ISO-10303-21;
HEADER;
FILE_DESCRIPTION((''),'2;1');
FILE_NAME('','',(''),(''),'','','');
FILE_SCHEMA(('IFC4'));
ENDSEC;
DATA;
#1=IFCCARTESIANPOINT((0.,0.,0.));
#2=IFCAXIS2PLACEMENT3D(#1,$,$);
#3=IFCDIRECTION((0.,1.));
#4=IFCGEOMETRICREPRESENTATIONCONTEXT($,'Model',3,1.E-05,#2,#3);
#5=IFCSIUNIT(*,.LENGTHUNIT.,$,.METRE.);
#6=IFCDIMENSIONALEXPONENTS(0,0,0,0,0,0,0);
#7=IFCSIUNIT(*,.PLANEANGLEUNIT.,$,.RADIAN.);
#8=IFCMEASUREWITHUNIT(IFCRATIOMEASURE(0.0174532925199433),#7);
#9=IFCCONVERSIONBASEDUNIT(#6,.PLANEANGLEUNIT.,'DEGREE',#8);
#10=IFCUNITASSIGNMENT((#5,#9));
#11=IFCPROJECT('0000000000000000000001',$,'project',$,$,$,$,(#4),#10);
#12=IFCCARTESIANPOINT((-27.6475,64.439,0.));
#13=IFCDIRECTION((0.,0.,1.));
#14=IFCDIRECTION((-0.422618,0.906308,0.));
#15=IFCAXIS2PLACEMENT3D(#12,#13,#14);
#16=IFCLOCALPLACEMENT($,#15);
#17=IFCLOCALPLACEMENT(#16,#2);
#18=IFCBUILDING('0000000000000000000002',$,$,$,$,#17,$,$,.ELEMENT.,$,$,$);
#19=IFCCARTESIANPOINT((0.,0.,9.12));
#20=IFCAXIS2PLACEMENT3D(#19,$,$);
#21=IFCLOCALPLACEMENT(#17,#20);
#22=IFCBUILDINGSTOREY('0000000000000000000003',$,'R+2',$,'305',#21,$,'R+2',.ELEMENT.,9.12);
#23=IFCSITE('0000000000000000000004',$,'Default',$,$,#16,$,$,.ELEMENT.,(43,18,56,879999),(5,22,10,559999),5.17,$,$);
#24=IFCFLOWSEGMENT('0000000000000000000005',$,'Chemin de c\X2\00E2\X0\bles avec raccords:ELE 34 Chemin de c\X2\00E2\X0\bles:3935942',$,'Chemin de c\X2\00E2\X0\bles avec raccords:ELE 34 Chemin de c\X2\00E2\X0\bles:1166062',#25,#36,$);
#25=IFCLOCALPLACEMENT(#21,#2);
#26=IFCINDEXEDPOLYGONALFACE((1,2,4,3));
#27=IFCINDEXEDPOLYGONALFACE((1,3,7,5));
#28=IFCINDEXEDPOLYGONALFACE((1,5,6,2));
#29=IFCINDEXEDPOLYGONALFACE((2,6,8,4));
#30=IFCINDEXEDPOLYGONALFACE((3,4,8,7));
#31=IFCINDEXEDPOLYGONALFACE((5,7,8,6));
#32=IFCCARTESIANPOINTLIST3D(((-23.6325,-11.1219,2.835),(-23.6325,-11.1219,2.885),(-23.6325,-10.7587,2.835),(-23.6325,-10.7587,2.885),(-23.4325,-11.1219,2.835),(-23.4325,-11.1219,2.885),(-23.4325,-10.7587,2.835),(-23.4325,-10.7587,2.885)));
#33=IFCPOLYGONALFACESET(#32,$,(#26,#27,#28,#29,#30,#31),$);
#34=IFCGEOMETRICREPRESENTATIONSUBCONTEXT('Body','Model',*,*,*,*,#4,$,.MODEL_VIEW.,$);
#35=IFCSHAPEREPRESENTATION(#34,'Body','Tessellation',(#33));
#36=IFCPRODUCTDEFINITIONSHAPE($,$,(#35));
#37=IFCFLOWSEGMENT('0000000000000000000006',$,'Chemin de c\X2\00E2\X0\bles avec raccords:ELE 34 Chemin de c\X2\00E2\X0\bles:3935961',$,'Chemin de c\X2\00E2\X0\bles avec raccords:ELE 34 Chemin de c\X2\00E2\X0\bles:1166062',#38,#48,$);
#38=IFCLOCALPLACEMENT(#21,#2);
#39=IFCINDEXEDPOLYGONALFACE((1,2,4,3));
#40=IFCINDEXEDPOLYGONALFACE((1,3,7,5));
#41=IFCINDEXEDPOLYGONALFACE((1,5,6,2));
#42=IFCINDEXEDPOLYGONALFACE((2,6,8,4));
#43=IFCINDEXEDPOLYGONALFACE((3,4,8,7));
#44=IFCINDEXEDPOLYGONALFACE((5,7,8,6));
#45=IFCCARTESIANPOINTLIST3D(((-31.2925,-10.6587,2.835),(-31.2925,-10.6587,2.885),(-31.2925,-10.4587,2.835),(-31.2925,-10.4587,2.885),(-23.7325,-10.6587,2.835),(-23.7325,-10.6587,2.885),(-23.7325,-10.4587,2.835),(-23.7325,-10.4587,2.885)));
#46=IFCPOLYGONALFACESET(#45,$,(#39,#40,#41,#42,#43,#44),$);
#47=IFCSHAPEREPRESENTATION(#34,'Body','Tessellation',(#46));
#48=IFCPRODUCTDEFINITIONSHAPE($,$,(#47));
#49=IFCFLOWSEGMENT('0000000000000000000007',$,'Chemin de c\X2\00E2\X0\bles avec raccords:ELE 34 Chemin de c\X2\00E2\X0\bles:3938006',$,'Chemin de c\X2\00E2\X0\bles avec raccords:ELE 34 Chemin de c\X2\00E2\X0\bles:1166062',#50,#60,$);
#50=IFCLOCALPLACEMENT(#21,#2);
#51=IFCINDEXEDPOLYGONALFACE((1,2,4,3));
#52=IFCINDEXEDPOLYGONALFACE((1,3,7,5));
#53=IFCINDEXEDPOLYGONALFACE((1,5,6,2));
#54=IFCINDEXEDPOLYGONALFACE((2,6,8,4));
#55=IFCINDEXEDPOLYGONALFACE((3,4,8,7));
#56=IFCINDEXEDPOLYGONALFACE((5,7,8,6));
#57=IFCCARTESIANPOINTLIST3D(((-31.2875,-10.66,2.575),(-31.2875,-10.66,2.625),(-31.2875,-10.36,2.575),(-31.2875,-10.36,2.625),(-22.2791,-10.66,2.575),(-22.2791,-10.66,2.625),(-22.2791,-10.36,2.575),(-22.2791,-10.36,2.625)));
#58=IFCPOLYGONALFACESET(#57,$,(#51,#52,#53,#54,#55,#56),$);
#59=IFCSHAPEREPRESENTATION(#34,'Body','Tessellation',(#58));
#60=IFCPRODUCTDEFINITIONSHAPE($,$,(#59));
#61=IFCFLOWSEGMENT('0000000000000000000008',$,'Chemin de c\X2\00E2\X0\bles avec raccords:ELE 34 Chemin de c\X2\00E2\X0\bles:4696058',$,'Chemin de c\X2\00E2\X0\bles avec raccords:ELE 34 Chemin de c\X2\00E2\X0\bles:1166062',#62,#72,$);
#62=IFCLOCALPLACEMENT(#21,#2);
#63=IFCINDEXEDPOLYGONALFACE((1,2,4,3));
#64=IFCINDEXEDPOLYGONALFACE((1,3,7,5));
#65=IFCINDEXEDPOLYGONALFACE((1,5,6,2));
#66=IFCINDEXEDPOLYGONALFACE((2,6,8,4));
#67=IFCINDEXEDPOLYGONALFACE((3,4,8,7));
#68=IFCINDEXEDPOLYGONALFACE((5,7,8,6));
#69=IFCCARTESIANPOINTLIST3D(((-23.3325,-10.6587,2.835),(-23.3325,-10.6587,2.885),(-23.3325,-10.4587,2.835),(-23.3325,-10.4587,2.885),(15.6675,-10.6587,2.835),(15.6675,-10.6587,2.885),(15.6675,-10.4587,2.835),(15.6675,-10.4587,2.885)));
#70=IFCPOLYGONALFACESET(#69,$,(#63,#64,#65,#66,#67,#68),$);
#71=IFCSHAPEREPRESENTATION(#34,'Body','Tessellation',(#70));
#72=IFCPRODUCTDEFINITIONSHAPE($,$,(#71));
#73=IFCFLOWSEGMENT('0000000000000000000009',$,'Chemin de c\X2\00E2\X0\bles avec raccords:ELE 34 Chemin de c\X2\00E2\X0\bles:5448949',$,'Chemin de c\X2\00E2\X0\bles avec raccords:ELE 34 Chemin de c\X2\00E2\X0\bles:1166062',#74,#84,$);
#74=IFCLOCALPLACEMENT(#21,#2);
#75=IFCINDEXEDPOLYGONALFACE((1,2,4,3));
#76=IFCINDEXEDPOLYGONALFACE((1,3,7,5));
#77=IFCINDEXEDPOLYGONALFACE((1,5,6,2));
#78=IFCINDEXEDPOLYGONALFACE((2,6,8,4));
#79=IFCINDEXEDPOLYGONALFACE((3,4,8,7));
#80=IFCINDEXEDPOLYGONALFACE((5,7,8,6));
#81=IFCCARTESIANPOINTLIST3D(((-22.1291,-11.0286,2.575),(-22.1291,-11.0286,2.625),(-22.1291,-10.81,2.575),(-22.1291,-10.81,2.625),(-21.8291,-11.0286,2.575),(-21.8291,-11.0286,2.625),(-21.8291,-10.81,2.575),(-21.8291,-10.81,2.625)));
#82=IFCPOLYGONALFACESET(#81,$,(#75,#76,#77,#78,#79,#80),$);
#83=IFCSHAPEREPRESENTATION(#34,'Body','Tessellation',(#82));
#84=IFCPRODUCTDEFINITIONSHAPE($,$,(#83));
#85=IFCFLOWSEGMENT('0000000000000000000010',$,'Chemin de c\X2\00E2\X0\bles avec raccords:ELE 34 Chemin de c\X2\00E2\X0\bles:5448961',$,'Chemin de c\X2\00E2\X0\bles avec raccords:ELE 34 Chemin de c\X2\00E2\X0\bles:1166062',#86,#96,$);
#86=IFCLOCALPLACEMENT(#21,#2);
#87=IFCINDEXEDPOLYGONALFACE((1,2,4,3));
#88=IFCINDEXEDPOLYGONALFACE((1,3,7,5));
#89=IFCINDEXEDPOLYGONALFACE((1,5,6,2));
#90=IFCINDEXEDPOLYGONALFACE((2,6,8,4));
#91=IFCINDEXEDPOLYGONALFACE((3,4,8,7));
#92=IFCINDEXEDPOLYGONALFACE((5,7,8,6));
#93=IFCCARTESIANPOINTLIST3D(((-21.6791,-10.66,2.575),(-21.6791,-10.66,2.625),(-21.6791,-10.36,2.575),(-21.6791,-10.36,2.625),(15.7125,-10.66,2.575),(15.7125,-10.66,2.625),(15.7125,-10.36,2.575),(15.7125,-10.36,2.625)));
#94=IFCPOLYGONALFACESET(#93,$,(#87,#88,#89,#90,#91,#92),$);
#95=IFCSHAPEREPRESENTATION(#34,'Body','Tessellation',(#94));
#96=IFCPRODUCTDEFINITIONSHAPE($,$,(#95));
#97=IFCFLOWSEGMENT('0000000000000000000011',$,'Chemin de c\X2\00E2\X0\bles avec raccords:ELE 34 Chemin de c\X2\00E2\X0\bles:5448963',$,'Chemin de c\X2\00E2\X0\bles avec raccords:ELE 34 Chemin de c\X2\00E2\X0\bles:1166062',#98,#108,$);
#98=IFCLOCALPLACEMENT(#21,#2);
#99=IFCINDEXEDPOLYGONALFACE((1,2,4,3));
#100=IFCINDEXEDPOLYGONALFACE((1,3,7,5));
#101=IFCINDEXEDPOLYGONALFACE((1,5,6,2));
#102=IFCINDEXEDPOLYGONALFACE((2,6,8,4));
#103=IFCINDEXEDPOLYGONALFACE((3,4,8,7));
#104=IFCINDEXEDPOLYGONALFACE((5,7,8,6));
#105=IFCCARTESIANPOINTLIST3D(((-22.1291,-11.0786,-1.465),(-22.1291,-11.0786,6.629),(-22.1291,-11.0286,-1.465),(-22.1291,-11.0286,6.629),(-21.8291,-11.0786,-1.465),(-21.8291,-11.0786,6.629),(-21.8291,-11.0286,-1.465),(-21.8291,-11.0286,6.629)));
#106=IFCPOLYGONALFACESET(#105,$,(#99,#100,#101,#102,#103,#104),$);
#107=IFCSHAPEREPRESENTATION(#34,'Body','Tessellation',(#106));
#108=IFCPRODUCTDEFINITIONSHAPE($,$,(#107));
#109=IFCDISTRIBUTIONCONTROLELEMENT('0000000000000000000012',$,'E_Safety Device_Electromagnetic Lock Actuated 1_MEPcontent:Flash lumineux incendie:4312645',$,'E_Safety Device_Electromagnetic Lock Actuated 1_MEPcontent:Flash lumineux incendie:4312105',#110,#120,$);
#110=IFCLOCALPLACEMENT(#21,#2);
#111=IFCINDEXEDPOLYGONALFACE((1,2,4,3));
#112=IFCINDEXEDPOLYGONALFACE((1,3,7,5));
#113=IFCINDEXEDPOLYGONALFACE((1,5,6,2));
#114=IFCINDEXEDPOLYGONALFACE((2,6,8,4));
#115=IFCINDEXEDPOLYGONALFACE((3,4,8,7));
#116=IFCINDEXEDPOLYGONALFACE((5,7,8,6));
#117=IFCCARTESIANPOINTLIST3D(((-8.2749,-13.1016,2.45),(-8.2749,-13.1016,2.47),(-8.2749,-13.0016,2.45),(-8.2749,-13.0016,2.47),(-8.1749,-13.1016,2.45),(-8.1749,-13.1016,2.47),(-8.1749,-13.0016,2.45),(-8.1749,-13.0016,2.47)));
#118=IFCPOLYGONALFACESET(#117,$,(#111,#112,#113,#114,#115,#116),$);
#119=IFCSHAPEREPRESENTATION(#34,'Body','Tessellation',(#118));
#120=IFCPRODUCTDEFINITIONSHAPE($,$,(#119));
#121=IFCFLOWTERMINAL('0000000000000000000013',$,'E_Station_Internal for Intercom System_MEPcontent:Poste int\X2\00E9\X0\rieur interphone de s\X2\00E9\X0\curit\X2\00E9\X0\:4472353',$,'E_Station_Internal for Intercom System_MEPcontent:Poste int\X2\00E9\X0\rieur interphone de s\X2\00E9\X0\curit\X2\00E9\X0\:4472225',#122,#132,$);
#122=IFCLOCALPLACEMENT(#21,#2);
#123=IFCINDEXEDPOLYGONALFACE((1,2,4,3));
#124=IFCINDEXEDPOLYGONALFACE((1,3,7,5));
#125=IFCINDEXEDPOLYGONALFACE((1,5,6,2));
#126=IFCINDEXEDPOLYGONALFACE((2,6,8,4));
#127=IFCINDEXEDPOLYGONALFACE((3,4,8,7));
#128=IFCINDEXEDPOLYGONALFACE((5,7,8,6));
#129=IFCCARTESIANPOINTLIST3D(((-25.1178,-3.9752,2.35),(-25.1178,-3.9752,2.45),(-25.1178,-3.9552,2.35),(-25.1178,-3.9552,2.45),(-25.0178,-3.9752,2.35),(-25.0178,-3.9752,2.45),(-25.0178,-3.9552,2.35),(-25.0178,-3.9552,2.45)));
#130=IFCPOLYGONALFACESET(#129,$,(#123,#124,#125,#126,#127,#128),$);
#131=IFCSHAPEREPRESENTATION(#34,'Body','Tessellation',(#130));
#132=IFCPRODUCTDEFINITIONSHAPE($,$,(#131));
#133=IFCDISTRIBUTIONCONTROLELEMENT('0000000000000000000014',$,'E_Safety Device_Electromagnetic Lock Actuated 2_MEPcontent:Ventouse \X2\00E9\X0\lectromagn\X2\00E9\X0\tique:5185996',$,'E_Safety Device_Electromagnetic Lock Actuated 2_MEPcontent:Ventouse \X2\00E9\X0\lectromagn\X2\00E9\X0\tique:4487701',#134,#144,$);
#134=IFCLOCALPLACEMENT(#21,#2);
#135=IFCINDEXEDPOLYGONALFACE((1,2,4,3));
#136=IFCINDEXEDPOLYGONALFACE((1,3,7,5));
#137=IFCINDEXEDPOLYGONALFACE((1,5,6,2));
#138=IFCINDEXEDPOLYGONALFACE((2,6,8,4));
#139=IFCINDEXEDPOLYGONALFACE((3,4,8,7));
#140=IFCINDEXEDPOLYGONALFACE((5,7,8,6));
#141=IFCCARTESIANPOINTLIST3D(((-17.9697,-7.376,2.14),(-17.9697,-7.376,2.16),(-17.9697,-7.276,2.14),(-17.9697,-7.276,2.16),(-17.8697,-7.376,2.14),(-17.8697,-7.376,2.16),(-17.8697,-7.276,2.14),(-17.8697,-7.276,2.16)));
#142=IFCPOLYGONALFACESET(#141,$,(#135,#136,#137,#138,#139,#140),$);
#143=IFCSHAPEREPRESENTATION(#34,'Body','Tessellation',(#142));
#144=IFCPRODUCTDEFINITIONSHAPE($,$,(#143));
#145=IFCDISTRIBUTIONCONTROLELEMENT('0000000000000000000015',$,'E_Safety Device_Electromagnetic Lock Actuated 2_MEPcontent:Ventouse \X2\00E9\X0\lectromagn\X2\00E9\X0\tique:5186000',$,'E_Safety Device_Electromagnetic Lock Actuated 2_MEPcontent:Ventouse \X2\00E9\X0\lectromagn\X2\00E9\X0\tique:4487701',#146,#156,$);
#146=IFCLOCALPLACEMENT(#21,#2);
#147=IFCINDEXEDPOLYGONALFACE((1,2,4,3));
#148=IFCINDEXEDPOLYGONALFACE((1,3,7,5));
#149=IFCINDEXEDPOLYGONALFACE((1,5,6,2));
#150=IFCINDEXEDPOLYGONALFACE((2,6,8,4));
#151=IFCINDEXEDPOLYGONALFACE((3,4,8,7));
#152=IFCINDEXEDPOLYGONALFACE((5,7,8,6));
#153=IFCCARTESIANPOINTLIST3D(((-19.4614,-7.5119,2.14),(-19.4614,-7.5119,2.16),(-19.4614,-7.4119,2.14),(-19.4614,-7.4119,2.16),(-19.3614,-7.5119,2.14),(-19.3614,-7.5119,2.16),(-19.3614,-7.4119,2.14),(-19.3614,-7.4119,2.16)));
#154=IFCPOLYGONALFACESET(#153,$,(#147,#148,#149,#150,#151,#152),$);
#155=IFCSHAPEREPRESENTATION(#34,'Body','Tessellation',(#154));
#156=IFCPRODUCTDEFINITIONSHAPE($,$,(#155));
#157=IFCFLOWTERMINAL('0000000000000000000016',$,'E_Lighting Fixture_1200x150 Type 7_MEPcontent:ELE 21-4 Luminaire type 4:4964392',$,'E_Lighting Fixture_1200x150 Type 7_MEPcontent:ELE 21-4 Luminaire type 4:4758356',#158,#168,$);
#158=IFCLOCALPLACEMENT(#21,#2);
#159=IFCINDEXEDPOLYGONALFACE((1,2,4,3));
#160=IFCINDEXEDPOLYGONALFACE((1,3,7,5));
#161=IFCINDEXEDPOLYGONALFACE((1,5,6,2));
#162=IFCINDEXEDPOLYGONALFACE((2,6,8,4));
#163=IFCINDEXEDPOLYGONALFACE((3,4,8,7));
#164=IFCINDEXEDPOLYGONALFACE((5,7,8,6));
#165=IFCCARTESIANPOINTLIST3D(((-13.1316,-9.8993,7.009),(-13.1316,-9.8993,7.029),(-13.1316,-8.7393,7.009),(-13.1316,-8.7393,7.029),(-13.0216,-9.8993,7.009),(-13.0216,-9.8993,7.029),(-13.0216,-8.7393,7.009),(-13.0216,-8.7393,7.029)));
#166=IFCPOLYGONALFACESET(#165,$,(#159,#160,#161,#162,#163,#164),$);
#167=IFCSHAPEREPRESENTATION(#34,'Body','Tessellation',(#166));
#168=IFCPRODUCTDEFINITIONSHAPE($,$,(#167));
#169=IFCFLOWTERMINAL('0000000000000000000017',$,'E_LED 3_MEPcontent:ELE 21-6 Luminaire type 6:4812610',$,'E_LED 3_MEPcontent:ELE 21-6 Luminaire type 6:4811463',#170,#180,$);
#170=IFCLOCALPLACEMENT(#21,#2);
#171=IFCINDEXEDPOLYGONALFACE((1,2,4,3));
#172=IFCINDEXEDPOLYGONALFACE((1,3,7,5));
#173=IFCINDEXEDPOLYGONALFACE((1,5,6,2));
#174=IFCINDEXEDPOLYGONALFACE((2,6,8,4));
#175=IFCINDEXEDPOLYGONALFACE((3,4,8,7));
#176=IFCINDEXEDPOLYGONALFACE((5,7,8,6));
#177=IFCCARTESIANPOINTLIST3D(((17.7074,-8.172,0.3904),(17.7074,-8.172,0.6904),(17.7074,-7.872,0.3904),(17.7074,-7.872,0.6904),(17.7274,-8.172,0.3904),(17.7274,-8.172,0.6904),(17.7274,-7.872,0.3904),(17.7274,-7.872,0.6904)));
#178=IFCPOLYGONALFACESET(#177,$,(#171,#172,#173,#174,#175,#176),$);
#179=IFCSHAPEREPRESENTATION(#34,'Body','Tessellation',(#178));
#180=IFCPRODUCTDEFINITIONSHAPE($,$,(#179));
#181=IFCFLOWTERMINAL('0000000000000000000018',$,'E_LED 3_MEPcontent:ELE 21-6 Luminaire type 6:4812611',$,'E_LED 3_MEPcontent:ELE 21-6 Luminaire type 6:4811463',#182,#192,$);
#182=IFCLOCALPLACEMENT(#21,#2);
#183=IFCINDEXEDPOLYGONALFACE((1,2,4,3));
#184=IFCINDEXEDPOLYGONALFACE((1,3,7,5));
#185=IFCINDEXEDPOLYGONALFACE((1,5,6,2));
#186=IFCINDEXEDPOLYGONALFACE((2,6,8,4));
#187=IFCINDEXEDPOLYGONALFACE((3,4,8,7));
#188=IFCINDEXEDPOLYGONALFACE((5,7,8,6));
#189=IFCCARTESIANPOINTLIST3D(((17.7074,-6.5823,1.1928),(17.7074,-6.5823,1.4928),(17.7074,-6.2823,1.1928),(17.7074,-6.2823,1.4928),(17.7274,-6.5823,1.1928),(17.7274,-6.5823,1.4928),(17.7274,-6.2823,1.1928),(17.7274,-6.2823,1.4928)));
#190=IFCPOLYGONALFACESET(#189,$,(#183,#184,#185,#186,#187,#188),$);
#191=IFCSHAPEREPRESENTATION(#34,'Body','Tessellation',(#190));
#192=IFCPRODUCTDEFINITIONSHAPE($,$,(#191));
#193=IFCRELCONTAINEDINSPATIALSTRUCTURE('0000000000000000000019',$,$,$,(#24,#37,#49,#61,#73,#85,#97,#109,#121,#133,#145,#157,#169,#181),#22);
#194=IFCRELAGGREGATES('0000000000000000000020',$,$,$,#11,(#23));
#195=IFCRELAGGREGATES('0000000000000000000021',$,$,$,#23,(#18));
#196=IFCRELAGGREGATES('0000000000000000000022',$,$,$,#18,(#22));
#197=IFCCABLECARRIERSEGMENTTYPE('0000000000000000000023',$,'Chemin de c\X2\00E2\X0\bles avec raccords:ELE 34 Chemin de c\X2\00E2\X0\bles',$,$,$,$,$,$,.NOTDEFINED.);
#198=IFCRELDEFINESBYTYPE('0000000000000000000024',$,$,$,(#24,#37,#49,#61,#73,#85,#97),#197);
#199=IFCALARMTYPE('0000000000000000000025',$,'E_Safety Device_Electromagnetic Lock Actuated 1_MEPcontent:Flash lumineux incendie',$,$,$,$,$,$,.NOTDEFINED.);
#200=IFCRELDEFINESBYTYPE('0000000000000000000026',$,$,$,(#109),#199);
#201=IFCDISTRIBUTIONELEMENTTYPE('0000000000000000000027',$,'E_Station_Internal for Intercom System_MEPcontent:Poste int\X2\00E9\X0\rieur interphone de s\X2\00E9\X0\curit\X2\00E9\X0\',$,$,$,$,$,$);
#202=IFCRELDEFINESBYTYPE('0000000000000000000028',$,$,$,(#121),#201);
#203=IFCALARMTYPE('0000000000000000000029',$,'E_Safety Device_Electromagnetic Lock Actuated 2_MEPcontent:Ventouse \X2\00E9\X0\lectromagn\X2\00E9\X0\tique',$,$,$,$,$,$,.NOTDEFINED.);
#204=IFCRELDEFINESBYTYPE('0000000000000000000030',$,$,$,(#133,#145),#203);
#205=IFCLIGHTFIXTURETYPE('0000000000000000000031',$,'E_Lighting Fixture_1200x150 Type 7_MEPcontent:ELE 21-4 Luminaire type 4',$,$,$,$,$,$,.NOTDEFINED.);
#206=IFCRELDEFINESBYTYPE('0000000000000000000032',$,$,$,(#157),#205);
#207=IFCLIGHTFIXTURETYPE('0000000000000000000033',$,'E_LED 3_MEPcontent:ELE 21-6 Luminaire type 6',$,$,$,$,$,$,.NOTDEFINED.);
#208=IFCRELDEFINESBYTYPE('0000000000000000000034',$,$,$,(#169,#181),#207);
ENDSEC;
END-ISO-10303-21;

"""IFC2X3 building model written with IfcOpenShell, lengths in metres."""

from ifc_helpers import new_model, entity, si_unit, converted_unit, direction, frame, frame_2d, origin, origin_2d_with_axis, place, context, subcontext, project, spatial, polyline, rectangle, outline, extrude, source, transform, mapped, type_object, type_shapes, element, save


model = new_model("IFC2X3")

# Units and contexts
model_context = context("Model", 3, precision=1e-05, world=origin(), true_north=direction((0.0, 1.0)))
body_context = subcontext(model_context, "Body", "Model", "MODEL_VIEW")
ifc_project = project(units=[si_unit("LENGTHUNIT", "METRE"), converted_unit("PLANEANGLEUNIT", "DEGREE", entity("IfcRatioMeasure", 0.0174532925199433), si_unit("PLANEANGLEUNIT", "RADIAN"), dimensions=[0, 0, 0, 0, 0, 0, 0])], contexts=[model_context])

# Site, building, storey
site_placement = place(None, frame((-27.6475, 64.439, 0.0), z_axis=(0.0, 0.0, 1.0), x_axis=(-0.422618, 0.906308, 0.0)))
site = spatial("IfcSite", under=ifc_project, at=site_placement, Name="Default", CompositionType="ELEMENT", RefLatitude=(43, 18, 56, 879999), RefLongitude=(5, 22, 10, 559999), RefElevation=5.17)
building_placement = place(site_placement, origin())
building = spatial("IfcBuilding", under=site, at=building_placement, CompositionType="ELEMENT")
storey_placement = place(building_placement, frame((0.0, 0.0, 9.12)))
storey = spatial("IfcBuildingStorey", under=building, at=storey_placement, Name="R+2", ObjectType="305", LongName="R+2", CompositionType="ELEMENT", Elevation=9.12)

# Flow segments
cable_carrier_segment_type = type_object("IfcCableCarrierSegmentType", Name="Chemin de câbles avec raccords:ELE 34 Chemin de câbles", PredefinedType="NOTDEFINED")
flow_segment_1_placement = place(storey_placement, origin())
element("IfcFlowSegment", 1, at=flow_segment_1_placement, inside=storey, type_object=cable_carrier_segment_type, Name="Chemin de câbles avec raccords:ELE 34 Chemin de câbles:3935942", ObjectType="Chemin de câbles avec raccords:ELE 34 Chemin de câbles:1166062", context=body_context, shape_type="SweptSolid", body=[
    extrude(outline(polyline([(-0.1, -0.1816), (0.1, -0.1816), (0.1, 0.1816), (-0.1, 0.1816), (-0.1, -0.1816)])), frame((-23.5325, -10.9403, 2.835)), (0.0, 0.0, 1.0), 0.05),
])
flow_segment_2_placement = place(storey_placement, origin())
element("IfcFlowSegment", 2, at=flow_segment_2_placement, inside=storey, type_object=cable_carrier_segment_type, Name="Chemin de câbles avec raccords:ELE 34 Chemin de câbles:3935961", ObjectType="Chemin de câbles avec raccords:ELE 34 Chemin de câbles:1166062", context=body_context, shape_type="SweptSolid", body=[
    extrude(rectangle(XDim=7.56, YDim=0.2, at=frame_2d((0.0, 0.0), x_axis=(1.0, 0.0))), frame((-27.5125, -10.5587, 2.835), z_axis=(0.0, 0.0, 1.0), x_axis=(-1.0, 0.0, 0.0)), (0.0, 0.0, 1.0), 0.05),
])
flow_segment_3_placement = place(storey_placement, origin())
element("IfcFlowSegment", 3, at=flow_segment_3_placement, inside=storey, type_object=cable_carrier_segment_type, Name="Chemin de câbles avec raccords:ELE 34 Chemin de câbles:3938006", ObjectType="Chemin de câbles avec raccords:ELE 34 Chemin de câbles:1166062", context=body_context, shape_type="SweptSolid", body=[
    extrude(rectangle(XDim=9.0084, YDim=0.3, at=frame_2d((0.0, 0.0), x_axis=(1.0, 0.0))), frame((-26.7833, -10.51, 2.575), z_axis=(0.0, 0.0, 1.0), x_axis=(-1.0, 0.0, 0.0)), (0.0, 0.0, 1.0), 0.05),
])
flow_segment_4_placement = place(storey_placement, origin())
element("IfcFlowSegment", 4, at=flow_segment_4_placement, inside=storey, type_object=cable_carrier_segment_type, Name="Chemin de câbles avec raccords:ELE 34 Chemin de câbles:4696058", ObjectType="Chemin de câbles avec raccords:ELE 34 Chemin de câbles:1166062", context=body_context, shape_type="SweptSolid", body=[
    extrude(rectangle(XDim=39.0, YDim=0.2, at=frame_2d((0.0, 0.0), x_axis=(1.0, 0.0))), frame((-3.8325, -10.5587, 2.835)), (0.0, 0.0, 1.0), 0.05),
])
flow_segment_5_placement = place(storey_placement, origin())
element("IfcFlowSegment", 5, at=flow_segment_5_placement, inside=storey, type_object=cable_carrier_segment_type, Name="Chemin de câbles avec raccords:ELE 34 Chemin de câbles:5448949", ObjectType="Chemin de câbles avec raccords:ELE 34 Chemin de câbles:1166062", context=body_context, shape_type="SweptSolid", body=[
    extrude(rectangle(XDim=0.2186, YDim=0.3, at=frame_2d((0.0, 0.0), x_axis=(1.0, 0.0))), frame((-21.9791, -10.9193, 2.575), z_axis=(0.0, 0.0, 1.0), x_axis=(0.0, -1.0, 0.0)), (0.0, 0.0, 1.0), 0.05),
])
flow_segment_6_placement = place(storey_placement, origin())
element("IfcFlowSegment", 6, at=flow_segment_6_placement, inside=storey, type_object=cable_carrier_segment_type, Name="Chemin de câbles avec raccords:ELE 34 Chemin de câbles:5448961", ObjectType="Chemin de câbles avec raccords:ELE 34 Chemin de câbles:1166062", context=body_context, shape_type="SweptSolid", body=[
    extrude(rectangle(XDim=37.3916, YDim=0.3, at=frame_2d((0.0, 0.0), x_axis=(1.0, 0.0))), frame((-2.9833, -10.51, 2.575), z_axis=(0.0, 0.0, 1.0), x_axis=(-1.0, 0.0, 0.0)), (0.0, 0.0, 1.0), 0.05),
])
flow_segment_7_placement = place(storey_placement, origin())
element("IfcFlowSegment", 7, at=flow_segment_7_placement, inside=storey, type_object=cable_carrier_segment_type, Name="Chemin de câbles avec raccords:ELE 34 Chemin de câbles:5448963", ObjectType="Chemin de câbles avec raccords:ELE 34 Chemin de câbles:1166062", context=body_context, shape_type="SweptSolid", body=[
    extrude(rectangle(XDim=0.3, YDim=0.05, at=origin_2d_with_axis()), frame((-21.9791, -11.0536, -1.465)), (0.0, 0.0, 1.0), 8.094),
])

# Distribution control element
alarm_type_1 = type_object("IfcAlarmType", Name="E_Safety Device_Electromagnetic Lock Actuated 1_MEPcontent:Flash lumineux incendie", PredefinedType="NOTDEFINED")
shared_shape_1 = source(origin(), body_context, "Body", "SweptSolid", [
    extrude(rectangle(XDim=0.1, YDim=0.1, at=origin_2d_with_axis()), frame((0.0, 0.0, 0.0), z_axis=(0.0, 0.0, 1.0), x_axis=(0.0, -1.0, 0.0)), (0.0, 0.0, 1.0), 0.02),
])
type_shapes(alarm_type_1, [shared_shape_1])
distribution_control_element_1_placement = place(storey_placement, frame((-8.2249, -13.0516, 2.45), z_axis=(0.0, 0.0, 1.0), x_axis=(0.0, -1.0, 0.0)))
element("IfcDistributionControlElement", 8, at=distribution_control_element_1_placement, inside=storey, type_object=alarm_type_1, Name="E_Safety Device_Electromagnetic Lock Actuated 1_MEPcontent:Flash lumineux incendie:4312645", ObjectType="E_Safety Device_Electromagnetic Lock Actuated 1_MEPcontent:Flash lumineux incendie:4312105", context=body_context, shape_type="MappedRepresentation", body=[
    mapped(shared_shape_1, transform((0.0, 0.0, 0.0), scale=1.0)),
])

# Flow terminal
distribution_element_type_1 = type_object("IfcDistributionElementType", Name="E_Station_Internal for Intercom System_MEPcontent:Poste intérieur interphone de sécurité")
shared_shape_2 = source(origin(), body_context, "Body", "SweptSolid", [
    extrude(rectangle(XDim=0.02, YDim=0.1, at=frame_2d((0.0, 0.0), x_axis=(1.0, 0.0))), frame((0.0, -0.01, -0.05), z_axis=(0.0, 0.0, 1.0), x_axis=(0.0, 1.0, 0.0)), (0.0, 0.0, 1.0), 0.1),
])
type_shapes(distribution_element_type_1, [shared_shape_2])
flow_terminal_1_placement = place(storey_placement, frame((-25.0678, -3.9552, 2.4)))
element("IfcFlowTerminal", 9, at=flow_terminal_1_placement, inside=storey, type_object=distribution_element_type_1, Name="E_Station_Internal for Intercom System_MEPcontent:Poste intérieur interphone de sécurité:4472353", ObjectType="E_Station_Internal for Intercom System_MEPcontent:Poste intérieur interphone de sécurité:4472225", context=body_context, shape_type="MappedRepresentation", body=[
    mapped(shared_shape_2, transform((0.0, 0.0, 0.0), scale=1.0)),
])

# Distribution control elements
alarm_type_2 = type_object("IfcAlarmType", Name="E_Safety Device_Electromagnetic Lock Actuated 2_MEPcontent:Ventouse électromagnétique", PredefinedType="NOTDEFINED")
shared_shape_3 = source(origin(), body_context, "Body", "SweptSolid", [
    extrude(rectangle(XDim=0.1, YDim=0.1, at=origin_2d_with_axis()), frame((0.0, 0.0, 0.0), z_axis=(0.0, 0.0, 1.0), x_axis=(0.0, -1.0, 0.0)), (0.0, 0.0, 1.0), 0.02),
])
type_shapes(alarm_type_2, [shared_shape_3])
distribution_control_element_2_placement = place(storey_placement, frame((-17.9197, -7.326, 2.14), z_axis=(0.0, 0.0, 1.0), x_axis=(0.0, 1.0, 0.0)))
element("IfcDistributionControlElement", 10, at=distribution_control_element_2_placement, inside=storey, type_object=alarm_type_2, Name="E_Safety Device_Electromagnetic Lock Actuated 2_MEPcontent:Ventouse électromagnétique:5185996", ObjectType="E_Safety Device_Electromagnetic Lock Actuated 2_MEPcontent:Ventouse électromagnétique:4487701", context=body_context, shape_type="MappedRepresentation", body=[
    mapped(shared_shape_3, transform((0.0, 0.0, 0.0), scale=1.0)),
])
distribution_control_element_3_placement = place(storey_placement, frame((-19.4114, -7.4619, 2.14)))
element("IfcDistributionControlElement", 11, at=distribution_control_element_3_placement, inside=storey, type_object=alarm_type_2, Name="E_Safety Device_Electromagnetic Lock Actuated 2_MEPcontent:Ventouse électromagnétique:5186000", ObjectType="E_Safety Device_Electromagnetic Lock Actuated 2_MEPcontent:Ventouse électromagnétique:4487701", context=body_context, shape_type="MappedRepresentation", body=[
    mapped(shared_shape_3, transform((0.0, 0.0, 0.0), scale=1.0)),
])

# Flow terminals
light_fixture_type_1 = type_object("IfcLightFixtureType", Name="E_Lighting Fixture_1200x150 Type 7_MEPcontent:ELE 21-4 Luminaire type 4", PredefinedType="NOTDEFINED")
shared_shape_4 = source(origin(), body_context, "Body", "SweptSolid", [
    extrude(rectangle(XDim=0.11, YDim=1.16, at=origin_2d_with_axis()), frame((0.0, 0.0, 0.0), z_axis=(0.0, 0.0, 1.0), x_axis=(0.0, -1.0, 0.0)), (0.0, 0.0, 1.0), 0.02),
])
type_shapes(light_fixture_type_1, [shared_shape_4])
flow_terminal_2_placement = place(storey_placement, frame((-13.0766, -9.3193, 7.009), z_axis=(0.0, 0.0, 1.0), x_axis=(0.0, -1.0, 0.0)))
element("IfcFlowTerminal", 12, at=flow_terminal_2_placement, inside=storey, type_object=light_fixture_type_1, Name="E_Lighting Fixture_1200x150 Type 7_MEPcontent:ELE 21-4 Luminaire type 4:4964392", ObjectType="E_Lighting Fixture_1200x150 Type 7_MEPcontent:ELE 21-4 Luminaire type 4:4758356", context=body_context, shape_type="MappedRepresentation", body=[
    mapped(shared_shape_4, transform((0.0, 0.0, 0.0), scale=1.0)),
])
light_fixture_type_2 = type_object("IfcLightFixtureType", Name="E_LED 3_MEPcontent:ELE 21-6 Luminaire type 6", PredefinedType="NOTDEFINED")
shared_shape_5 = source(origin(), body_context, "Body", "SweptSolid", [
    extrude(rectangle(XDim=0.02, YDim=0.3, at=origin_2d_with_axis()), frame((0.0, 0.01, -0.15), z_axis=(0.0, 0.0, 1.0), x_axis=(0.0, -1.0, 0.0)), (0.0, 0.0, 1.0), 0.3),
])
type_shapes(light_fixture_type_2, [shared_shape_5])
for number, where, z_axis, x_axis, name in (
    (13, (17.7074, -8.022, 0.5404), (0.0, 0.0, 1.0), (0.0, -1.0, 0.0), "E_LED 3_MEPcontent:ELE 21-6 Luminaire type 6:4812610"),
    (14, (17.7074, -6.4323, 1.3428), (0.0, 0.0, 1.0), (0.0, -1.0, 0.0), "E_LED 3_MEPcontent:ELE 21-6 Luminaire type 6:4812611"),
):
    element("IfcFlowTerminal", number, at=place(storey_placement, frame(where, z_axis=z_axis, x_axis=x_axis)), inside=storey, type_object=light_fixture_type_2, Name=name, ObjectType="E_LED 3_MEPcontent:ELE 21-6 Luminaire type 6:4811463", context=body_context, shape_type="MappedRepresentation", body=[
        mapped(shared_shape_5, transform((0.0, 0.0, 0.0), scale=1.0)),
    ])

save(model, "model.ifc")
